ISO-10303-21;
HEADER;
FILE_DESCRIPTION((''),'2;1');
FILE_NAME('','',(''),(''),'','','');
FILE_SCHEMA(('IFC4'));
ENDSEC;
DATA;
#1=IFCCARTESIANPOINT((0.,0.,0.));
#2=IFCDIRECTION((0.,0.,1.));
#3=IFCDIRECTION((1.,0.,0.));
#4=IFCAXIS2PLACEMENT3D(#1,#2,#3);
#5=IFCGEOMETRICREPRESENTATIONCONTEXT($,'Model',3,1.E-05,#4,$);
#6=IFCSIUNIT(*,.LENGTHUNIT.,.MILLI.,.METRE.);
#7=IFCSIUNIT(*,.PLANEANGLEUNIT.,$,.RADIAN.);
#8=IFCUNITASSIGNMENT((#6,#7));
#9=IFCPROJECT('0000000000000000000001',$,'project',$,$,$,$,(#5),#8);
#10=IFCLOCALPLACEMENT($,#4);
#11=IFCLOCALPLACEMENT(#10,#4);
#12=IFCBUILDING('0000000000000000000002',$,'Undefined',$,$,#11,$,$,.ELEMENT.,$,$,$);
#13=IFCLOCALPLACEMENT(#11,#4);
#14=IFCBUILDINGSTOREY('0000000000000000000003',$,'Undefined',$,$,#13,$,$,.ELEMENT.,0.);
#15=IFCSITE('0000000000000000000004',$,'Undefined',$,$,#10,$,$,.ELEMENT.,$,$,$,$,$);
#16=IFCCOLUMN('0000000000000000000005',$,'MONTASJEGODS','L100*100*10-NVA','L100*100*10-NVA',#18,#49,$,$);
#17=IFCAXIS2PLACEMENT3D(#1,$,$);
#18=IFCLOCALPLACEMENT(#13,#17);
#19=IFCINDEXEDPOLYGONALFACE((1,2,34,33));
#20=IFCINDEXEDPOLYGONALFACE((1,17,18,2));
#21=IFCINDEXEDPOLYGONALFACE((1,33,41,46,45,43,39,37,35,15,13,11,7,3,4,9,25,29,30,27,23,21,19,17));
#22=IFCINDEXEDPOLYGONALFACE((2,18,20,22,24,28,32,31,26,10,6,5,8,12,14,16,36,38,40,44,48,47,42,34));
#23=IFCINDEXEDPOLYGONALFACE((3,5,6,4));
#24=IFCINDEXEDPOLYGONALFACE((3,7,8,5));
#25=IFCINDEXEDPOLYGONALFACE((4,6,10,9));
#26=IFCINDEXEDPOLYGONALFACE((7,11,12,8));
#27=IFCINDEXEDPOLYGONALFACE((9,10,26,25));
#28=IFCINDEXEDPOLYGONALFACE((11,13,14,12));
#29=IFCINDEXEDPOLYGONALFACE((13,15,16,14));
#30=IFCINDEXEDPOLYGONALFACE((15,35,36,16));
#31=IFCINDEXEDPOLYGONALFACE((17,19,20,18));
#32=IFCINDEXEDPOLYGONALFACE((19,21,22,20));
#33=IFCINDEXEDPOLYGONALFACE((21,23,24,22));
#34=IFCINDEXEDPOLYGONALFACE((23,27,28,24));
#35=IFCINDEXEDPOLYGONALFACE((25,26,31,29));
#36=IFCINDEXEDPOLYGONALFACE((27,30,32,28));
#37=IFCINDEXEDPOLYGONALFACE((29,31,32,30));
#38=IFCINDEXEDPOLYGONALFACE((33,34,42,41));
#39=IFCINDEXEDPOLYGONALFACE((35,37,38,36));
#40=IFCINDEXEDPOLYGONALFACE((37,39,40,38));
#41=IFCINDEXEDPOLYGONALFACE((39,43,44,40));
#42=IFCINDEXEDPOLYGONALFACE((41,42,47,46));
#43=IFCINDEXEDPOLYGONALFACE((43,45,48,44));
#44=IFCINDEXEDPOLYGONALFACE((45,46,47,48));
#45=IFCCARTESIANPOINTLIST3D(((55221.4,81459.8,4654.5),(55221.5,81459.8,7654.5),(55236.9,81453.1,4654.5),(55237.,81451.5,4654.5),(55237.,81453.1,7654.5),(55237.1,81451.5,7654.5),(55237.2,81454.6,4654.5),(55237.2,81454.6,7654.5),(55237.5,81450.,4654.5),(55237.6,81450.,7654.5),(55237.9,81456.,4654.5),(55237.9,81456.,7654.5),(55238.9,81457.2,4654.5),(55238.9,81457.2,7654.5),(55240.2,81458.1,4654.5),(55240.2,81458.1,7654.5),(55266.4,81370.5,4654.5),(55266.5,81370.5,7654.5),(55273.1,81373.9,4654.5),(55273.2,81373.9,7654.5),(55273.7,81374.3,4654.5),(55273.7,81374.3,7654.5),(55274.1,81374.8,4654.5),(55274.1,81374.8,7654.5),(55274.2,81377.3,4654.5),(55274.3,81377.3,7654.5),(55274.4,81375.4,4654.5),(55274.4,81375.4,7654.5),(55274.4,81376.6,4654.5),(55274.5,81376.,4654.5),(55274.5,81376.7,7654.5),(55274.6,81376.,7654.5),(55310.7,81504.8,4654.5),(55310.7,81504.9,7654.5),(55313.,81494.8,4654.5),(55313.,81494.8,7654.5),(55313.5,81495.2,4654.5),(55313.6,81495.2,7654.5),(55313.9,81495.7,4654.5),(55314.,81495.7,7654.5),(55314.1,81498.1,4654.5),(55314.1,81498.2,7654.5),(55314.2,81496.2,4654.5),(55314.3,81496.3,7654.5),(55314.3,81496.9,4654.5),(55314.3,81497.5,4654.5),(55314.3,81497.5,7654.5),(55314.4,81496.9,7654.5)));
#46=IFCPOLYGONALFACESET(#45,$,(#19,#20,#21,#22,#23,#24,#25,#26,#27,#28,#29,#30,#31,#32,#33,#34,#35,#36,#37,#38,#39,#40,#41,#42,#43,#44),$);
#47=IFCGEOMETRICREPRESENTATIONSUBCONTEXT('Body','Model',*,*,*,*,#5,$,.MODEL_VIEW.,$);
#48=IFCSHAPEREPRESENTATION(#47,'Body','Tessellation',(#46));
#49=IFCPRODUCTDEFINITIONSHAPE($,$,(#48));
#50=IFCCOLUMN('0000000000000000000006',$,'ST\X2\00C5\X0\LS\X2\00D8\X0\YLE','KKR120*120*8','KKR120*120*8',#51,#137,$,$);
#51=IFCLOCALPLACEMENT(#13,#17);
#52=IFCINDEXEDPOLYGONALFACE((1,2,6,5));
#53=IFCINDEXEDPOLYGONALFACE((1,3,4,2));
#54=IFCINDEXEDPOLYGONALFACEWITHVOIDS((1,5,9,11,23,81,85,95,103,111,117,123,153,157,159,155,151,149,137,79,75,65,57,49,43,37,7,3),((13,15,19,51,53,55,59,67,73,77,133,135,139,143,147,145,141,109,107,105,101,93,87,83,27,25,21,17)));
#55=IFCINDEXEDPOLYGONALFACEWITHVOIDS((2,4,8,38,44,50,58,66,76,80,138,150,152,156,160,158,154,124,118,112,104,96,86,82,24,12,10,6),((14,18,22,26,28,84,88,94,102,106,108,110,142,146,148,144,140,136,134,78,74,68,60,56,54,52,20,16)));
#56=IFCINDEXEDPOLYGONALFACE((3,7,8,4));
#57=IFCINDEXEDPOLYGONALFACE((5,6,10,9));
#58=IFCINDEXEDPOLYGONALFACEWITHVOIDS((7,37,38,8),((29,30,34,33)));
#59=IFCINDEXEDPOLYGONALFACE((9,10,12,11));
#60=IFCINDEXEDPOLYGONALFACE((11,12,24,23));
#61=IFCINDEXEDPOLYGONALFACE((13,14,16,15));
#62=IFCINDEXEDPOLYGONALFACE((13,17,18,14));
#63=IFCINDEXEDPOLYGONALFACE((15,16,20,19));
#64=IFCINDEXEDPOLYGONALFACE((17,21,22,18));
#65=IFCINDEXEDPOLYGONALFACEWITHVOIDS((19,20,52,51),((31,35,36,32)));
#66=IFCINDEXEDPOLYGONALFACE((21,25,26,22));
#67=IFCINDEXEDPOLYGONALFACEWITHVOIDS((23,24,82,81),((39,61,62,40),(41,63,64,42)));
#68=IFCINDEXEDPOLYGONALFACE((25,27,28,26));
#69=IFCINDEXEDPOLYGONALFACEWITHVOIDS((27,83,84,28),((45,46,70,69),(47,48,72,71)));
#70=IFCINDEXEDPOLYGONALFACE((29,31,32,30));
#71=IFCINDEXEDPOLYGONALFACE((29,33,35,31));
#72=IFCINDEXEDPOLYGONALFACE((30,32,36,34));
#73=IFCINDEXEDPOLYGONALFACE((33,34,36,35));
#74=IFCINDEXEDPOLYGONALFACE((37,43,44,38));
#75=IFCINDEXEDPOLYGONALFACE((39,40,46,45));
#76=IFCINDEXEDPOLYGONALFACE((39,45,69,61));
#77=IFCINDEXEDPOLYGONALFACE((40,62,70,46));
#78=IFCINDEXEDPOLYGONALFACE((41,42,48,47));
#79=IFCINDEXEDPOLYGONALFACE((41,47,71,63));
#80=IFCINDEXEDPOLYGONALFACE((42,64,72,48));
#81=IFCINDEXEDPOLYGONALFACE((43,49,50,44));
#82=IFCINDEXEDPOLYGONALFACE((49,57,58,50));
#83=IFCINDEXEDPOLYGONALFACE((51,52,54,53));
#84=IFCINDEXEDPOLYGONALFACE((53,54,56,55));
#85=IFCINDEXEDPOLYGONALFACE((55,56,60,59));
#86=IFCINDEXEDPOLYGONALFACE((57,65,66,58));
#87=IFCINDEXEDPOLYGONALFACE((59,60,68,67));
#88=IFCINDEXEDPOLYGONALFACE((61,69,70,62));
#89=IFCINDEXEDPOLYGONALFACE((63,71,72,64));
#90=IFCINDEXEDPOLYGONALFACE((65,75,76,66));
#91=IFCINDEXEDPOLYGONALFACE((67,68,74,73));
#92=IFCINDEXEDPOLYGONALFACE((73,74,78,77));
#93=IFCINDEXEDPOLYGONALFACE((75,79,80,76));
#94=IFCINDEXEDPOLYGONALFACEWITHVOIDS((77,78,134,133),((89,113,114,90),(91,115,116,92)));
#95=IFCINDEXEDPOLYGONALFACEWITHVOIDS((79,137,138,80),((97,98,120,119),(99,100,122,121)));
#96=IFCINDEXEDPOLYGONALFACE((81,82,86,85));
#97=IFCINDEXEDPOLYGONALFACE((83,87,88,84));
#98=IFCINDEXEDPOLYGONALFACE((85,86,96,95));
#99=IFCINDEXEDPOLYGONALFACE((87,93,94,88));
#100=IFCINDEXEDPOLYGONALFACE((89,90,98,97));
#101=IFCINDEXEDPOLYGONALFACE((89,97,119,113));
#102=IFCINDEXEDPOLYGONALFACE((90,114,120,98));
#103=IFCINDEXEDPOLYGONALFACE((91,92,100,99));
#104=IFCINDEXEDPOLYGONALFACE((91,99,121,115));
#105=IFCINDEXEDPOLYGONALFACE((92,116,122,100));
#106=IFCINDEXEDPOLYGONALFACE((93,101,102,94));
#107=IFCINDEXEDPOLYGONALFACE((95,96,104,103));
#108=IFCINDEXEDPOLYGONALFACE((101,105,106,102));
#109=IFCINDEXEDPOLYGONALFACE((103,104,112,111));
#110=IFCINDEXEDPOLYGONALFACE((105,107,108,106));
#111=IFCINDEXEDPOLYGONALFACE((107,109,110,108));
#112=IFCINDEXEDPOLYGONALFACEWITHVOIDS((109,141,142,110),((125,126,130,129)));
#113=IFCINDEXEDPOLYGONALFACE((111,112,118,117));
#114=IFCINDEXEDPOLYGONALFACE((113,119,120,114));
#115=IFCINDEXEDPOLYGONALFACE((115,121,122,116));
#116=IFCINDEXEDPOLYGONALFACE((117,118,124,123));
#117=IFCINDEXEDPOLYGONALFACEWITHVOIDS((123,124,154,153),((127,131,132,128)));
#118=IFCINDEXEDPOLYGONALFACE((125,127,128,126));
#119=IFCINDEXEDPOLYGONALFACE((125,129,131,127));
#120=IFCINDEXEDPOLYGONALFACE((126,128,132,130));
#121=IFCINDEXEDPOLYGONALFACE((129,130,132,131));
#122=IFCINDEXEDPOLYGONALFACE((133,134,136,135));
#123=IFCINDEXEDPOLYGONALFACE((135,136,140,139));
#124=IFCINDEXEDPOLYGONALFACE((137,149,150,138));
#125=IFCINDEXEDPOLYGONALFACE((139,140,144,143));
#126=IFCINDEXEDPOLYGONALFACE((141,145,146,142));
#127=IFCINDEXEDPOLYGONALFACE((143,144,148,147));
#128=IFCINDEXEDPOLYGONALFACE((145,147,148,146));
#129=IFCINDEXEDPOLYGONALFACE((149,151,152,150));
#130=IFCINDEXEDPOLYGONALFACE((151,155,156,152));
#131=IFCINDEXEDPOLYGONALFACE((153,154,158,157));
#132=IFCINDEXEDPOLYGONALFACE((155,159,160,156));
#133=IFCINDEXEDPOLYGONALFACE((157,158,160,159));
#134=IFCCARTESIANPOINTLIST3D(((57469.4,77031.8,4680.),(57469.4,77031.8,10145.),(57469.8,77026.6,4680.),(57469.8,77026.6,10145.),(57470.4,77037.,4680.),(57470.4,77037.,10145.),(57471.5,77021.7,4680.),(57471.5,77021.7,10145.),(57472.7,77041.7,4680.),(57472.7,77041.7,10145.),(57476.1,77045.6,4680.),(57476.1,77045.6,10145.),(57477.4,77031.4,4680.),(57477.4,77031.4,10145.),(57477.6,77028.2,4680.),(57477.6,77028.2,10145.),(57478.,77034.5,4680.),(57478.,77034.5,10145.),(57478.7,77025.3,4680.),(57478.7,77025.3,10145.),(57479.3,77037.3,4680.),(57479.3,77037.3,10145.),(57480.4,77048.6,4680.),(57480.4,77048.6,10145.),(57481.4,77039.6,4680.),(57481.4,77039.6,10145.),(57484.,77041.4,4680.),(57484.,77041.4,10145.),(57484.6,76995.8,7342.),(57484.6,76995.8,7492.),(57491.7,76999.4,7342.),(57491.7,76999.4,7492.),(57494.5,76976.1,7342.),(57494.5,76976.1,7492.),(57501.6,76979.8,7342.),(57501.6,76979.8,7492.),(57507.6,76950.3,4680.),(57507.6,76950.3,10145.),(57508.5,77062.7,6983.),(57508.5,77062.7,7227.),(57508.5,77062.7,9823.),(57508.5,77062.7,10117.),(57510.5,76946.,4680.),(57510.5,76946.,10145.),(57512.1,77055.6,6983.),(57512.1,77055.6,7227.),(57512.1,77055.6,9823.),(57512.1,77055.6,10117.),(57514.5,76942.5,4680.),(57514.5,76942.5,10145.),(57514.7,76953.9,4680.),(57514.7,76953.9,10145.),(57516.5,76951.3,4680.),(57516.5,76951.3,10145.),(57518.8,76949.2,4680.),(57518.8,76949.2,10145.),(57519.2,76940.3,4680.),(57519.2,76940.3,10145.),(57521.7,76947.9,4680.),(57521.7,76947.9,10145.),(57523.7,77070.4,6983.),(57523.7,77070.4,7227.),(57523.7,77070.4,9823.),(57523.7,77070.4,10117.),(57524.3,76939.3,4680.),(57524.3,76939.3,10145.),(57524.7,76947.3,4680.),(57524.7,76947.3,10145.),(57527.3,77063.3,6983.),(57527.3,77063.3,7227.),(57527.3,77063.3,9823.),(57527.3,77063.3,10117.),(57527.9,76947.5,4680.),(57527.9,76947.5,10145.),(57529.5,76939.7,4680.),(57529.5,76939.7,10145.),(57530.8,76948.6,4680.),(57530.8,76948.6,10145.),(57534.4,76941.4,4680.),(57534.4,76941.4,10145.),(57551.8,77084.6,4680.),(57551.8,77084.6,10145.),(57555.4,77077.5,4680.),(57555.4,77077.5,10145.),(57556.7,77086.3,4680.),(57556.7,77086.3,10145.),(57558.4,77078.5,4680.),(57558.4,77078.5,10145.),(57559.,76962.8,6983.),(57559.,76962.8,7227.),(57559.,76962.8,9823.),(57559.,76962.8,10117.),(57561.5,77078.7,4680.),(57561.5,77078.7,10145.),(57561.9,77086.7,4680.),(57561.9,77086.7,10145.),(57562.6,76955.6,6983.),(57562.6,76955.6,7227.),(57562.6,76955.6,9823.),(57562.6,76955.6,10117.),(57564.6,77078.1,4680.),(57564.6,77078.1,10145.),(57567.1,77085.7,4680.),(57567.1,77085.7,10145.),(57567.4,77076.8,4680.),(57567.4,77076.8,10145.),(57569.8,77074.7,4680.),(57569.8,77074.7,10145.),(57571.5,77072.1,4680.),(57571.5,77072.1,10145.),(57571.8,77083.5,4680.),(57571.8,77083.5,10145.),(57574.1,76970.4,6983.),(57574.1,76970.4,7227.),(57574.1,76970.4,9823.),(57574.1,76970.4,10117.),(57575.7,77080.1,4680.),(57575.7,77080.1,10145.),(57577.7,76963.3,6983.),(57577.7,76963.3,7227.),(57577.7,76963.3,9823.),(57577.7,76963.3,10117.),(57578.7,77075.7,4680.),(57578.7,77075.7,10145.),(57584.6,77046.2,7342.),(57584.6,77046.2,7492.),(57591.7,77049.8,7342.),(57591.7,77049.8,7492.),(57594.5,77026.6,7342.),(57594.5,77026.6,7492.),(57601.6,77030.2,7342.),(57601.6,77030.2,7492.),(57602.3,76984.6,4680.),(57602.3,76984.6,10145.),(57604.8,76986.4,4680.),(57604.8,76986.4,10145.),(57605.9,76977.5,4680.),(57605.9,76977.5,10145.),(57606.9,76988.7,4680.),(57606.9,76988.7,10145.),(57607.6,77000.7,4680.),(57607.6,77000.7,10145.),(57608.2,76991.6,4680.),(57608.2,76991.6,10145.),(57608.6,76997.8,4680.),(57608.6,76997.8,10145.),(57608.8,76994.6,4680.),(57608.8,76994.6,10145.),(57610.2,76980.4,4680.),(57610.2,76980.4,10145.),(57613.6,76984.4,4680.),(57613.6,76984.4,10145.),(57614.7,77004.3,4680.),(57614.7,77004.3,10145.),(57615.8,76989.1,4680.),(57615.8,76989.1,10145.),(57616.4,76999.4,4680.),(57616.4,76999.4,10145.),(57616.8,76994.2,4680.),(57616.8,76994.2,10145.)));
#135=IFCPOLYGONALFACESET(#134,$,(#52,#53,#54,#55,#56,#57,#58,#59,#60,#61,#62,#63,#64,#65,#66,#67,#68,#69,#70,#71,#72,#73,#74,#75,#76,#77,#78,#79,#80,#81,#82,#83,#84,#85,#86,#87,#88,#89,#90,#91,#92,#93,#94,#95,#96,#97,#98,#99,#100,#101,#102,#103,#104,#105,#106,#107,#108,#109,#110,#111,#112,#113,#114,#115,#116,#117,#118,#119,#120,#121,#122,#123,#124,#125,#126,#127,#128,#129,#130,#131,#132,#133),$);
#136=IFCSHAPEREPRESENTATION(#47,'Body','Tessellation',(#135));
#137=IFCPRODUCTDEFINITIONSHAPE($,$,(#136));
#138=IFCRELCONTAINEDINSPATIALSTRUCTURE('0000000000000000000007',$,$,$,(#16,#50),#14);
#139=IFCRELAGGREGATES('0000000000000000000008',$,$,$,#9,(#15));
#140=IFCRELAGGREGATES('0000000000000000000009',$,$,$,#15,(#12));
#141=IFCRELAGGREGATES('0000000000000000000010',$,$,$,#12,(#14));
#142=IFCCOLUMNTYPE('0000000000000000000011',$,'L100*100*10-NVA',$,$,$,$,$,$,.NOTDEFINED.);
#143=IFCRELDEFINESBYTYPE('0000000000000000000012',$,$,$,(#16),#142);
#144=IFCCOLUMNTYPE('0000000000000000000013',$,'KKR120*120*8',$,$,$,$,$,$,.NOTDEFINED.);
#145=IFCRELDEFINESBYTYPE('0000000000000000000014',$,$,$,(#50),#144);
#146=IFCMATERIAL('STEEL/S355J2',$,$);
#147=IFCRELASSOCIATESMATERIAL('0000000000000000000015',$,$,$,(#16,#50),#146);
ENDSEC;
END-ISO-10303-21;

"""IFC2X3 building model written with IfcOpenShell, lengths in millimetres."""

from ifc_helpers import new_model, si_unit, frame, origin_with_axes, origin_2d_with_axis, place, context, subcontext, project, spatial, polyline, hollow_rectangle, l_section, outline, extrude, boolean, halfspace, material, type_object, element, save


model = new_model("IFC2X3")

# Units and contexts
model_context = context("Model", 3, precision=1e-05, world=origin_with_axes())
body_context = subcontext(model_context, "Body", "Model", "MODEL_VIEW")
ifc_project = project(units=[si_unit("LENGTHUNIT", "METRE", prefix="MILLI"), si_unit("PLANEANGLEUNIT", "RADIAN")], contexts=[model_context])

# Site, building, storey
site_placement = place(None, origin_with_axes())
site = spatial("IfcSite", under=ifc_project, at=site_placement, Name="Undefined", CompositionType="ELEMENT")
building_placement = place(site_placement, origin_with_axes())
building = spatial("IfcBuilding", under=site, at=building_placement, Name="Undefined", CompositionType="ELEMENT")
storey_placement = place(building_placement, origin_with_axes())
storey = spatial("IfcBuildingStorey", under=building, at=storey_placement, Name="Undefined", CompositionType="ELEMENT", Elevation=0.0)

# Columns
ifc_material_1 = material(Name="STEEL/S355J2")
column_type_1 = type_object("IfcColumnType", Name="L100*100*10-NVA", PredefinedType="NOTDEFINED")
column_1_placement = place(storey_placement, frame((55288.6, 81437.7, 4654.5), z_axis=(0.000019, 0.000006, 1.0), x_axis=(0.450294, -0.89288, -0.000003)))
element("IfcColumn", 1, at=column_1_placement, inside=storey, type_object=column_type_1, material=ifc_material_1, Name="MONTASJEGODS", Description="L100*100*10-NVA", ObjectType="L100*100*10-NVA", context=body_context, shape_type="SweptSolid", body=[
    extrude(l_section(Depth=100.0, Width=100.0, Thickness=10.0, FilletRadius=6.0, EdgeRadius=2.5, at=origin_2d_with_axis()), frame((0.0, 0.0, 3000.0), z_axis=(0.0, 0.0, -1.0), x_axis=(0.0, 1.0, 0.0)), (0.0, 0.0, 1.0), 3000.0),
])
column_type_2 = type_object("IfcColumnType", Name="KKR120*120*8", PredefinedType="NOTDEFINED")
column_2_placement = place(storey_placement, frame((57543.1, 77013.0, 4680.0), z_axis=(0.0, 0.0, 1.0), x_axis=(0.450512, -0.89277, 0.0)))
element("IfcColumn", 2, at=column_2_placement, inside=storey, type_object=column_type_2, material=ifc_material_1, Name="STÅLSØYLE", Description="KKR120*120*8", ObjectType="KKR120*120*8", context=body_context, shape_type="CSG", body=[
    boolean("DIFFERENCE", boolean("DIFFERENCE", boolean("DIFFERENCE", boolean("DIFFERENCE", boolean("DIFFERENCE", boolean("DIFFERENCE", extrude(hollow_rectangle(XDim=120.0, YDim=120.0, WallThickness=8.0, InnerFilletRadius=12.0, OuterFilletRadius=20.0, at=origin_2d_with_axis()), frame((0.0, 0.0, 5465.0), z_axis=(0.0, 0.0, -1.0), x_axis=(0.0, 1.0, 0.0)), (0.0, 0.0, 1.0), 5465.0), extrude(outline(polyline([(0.0, 0.0), (245.0, 0.0), (245.0, 150.0), (0.0, 150.0), (0.0, 0.0)])), frame((-11.0, 70.0, 2812.0), z_axis=(1.0, -0.000114, 0.0), x_axis=(-0.000114, -1.0, 0.0)), (0.0, 0.0, 1.0), 22.0)), extrude(outline(polyline([(0.0, 0.0), (17.0, 0.0), (17.0, 244.0), (0.0, 244.0), (0.0, 0.0)])), frame((42.0, 8.5, 2547.0), z_axis=(1.0, -0.000113, 0.0), x_axis=(-0.000113, -1.0, 0.0)), (0.0, 0.0, 1.0), 28.0)), extrude(outline(polyline([(0.0, 0.0), (17.0, 0.0), (17.0, 244.0), (0.0, 244.0), (0.0, 0.0)])), frame((-70.0, 8.5, 2547.0), z_axis=(1.0, -0.000113, 0.0), x_axis=(-0.000113, -1.0, 0.0)), (0.0, 0.0, 1.0), 28.0)), extrude(outline(polyline([(0.0, 0.0), (17.0, 0.0), (17.0, 294.0), (0.0, 294.0), (0.0, 0.0)])), frame((42.0, 8.5, 5437.0), z_axis=(1.0, -0.000113, 0.0), x_axis=(-0.000113, -1.0, 0.0)), (0.0, 0.0, 1.0), 28.0)), extrude(outline(polyline([(0.0, 0.0), (17.0, 0.0), (17.0, 294.0), (0.0, 294.0), (0.0, 0.0)])), frame((-70.0, 8.5, 5437.0), z_axis=(1.0, -0.000113, 0.0), x_axis=(-0.000113, -1.0, 0.0)), (0.0, 0.0, 1.0), 28.0)), halfspace(frame((-60.0, 0.0, 5465.0), z_axis=(0.0, 0.0, -1.0), x_axis=(0.0, -1.0, 0.0)), True)),
])

save(model, "model.ifc")
